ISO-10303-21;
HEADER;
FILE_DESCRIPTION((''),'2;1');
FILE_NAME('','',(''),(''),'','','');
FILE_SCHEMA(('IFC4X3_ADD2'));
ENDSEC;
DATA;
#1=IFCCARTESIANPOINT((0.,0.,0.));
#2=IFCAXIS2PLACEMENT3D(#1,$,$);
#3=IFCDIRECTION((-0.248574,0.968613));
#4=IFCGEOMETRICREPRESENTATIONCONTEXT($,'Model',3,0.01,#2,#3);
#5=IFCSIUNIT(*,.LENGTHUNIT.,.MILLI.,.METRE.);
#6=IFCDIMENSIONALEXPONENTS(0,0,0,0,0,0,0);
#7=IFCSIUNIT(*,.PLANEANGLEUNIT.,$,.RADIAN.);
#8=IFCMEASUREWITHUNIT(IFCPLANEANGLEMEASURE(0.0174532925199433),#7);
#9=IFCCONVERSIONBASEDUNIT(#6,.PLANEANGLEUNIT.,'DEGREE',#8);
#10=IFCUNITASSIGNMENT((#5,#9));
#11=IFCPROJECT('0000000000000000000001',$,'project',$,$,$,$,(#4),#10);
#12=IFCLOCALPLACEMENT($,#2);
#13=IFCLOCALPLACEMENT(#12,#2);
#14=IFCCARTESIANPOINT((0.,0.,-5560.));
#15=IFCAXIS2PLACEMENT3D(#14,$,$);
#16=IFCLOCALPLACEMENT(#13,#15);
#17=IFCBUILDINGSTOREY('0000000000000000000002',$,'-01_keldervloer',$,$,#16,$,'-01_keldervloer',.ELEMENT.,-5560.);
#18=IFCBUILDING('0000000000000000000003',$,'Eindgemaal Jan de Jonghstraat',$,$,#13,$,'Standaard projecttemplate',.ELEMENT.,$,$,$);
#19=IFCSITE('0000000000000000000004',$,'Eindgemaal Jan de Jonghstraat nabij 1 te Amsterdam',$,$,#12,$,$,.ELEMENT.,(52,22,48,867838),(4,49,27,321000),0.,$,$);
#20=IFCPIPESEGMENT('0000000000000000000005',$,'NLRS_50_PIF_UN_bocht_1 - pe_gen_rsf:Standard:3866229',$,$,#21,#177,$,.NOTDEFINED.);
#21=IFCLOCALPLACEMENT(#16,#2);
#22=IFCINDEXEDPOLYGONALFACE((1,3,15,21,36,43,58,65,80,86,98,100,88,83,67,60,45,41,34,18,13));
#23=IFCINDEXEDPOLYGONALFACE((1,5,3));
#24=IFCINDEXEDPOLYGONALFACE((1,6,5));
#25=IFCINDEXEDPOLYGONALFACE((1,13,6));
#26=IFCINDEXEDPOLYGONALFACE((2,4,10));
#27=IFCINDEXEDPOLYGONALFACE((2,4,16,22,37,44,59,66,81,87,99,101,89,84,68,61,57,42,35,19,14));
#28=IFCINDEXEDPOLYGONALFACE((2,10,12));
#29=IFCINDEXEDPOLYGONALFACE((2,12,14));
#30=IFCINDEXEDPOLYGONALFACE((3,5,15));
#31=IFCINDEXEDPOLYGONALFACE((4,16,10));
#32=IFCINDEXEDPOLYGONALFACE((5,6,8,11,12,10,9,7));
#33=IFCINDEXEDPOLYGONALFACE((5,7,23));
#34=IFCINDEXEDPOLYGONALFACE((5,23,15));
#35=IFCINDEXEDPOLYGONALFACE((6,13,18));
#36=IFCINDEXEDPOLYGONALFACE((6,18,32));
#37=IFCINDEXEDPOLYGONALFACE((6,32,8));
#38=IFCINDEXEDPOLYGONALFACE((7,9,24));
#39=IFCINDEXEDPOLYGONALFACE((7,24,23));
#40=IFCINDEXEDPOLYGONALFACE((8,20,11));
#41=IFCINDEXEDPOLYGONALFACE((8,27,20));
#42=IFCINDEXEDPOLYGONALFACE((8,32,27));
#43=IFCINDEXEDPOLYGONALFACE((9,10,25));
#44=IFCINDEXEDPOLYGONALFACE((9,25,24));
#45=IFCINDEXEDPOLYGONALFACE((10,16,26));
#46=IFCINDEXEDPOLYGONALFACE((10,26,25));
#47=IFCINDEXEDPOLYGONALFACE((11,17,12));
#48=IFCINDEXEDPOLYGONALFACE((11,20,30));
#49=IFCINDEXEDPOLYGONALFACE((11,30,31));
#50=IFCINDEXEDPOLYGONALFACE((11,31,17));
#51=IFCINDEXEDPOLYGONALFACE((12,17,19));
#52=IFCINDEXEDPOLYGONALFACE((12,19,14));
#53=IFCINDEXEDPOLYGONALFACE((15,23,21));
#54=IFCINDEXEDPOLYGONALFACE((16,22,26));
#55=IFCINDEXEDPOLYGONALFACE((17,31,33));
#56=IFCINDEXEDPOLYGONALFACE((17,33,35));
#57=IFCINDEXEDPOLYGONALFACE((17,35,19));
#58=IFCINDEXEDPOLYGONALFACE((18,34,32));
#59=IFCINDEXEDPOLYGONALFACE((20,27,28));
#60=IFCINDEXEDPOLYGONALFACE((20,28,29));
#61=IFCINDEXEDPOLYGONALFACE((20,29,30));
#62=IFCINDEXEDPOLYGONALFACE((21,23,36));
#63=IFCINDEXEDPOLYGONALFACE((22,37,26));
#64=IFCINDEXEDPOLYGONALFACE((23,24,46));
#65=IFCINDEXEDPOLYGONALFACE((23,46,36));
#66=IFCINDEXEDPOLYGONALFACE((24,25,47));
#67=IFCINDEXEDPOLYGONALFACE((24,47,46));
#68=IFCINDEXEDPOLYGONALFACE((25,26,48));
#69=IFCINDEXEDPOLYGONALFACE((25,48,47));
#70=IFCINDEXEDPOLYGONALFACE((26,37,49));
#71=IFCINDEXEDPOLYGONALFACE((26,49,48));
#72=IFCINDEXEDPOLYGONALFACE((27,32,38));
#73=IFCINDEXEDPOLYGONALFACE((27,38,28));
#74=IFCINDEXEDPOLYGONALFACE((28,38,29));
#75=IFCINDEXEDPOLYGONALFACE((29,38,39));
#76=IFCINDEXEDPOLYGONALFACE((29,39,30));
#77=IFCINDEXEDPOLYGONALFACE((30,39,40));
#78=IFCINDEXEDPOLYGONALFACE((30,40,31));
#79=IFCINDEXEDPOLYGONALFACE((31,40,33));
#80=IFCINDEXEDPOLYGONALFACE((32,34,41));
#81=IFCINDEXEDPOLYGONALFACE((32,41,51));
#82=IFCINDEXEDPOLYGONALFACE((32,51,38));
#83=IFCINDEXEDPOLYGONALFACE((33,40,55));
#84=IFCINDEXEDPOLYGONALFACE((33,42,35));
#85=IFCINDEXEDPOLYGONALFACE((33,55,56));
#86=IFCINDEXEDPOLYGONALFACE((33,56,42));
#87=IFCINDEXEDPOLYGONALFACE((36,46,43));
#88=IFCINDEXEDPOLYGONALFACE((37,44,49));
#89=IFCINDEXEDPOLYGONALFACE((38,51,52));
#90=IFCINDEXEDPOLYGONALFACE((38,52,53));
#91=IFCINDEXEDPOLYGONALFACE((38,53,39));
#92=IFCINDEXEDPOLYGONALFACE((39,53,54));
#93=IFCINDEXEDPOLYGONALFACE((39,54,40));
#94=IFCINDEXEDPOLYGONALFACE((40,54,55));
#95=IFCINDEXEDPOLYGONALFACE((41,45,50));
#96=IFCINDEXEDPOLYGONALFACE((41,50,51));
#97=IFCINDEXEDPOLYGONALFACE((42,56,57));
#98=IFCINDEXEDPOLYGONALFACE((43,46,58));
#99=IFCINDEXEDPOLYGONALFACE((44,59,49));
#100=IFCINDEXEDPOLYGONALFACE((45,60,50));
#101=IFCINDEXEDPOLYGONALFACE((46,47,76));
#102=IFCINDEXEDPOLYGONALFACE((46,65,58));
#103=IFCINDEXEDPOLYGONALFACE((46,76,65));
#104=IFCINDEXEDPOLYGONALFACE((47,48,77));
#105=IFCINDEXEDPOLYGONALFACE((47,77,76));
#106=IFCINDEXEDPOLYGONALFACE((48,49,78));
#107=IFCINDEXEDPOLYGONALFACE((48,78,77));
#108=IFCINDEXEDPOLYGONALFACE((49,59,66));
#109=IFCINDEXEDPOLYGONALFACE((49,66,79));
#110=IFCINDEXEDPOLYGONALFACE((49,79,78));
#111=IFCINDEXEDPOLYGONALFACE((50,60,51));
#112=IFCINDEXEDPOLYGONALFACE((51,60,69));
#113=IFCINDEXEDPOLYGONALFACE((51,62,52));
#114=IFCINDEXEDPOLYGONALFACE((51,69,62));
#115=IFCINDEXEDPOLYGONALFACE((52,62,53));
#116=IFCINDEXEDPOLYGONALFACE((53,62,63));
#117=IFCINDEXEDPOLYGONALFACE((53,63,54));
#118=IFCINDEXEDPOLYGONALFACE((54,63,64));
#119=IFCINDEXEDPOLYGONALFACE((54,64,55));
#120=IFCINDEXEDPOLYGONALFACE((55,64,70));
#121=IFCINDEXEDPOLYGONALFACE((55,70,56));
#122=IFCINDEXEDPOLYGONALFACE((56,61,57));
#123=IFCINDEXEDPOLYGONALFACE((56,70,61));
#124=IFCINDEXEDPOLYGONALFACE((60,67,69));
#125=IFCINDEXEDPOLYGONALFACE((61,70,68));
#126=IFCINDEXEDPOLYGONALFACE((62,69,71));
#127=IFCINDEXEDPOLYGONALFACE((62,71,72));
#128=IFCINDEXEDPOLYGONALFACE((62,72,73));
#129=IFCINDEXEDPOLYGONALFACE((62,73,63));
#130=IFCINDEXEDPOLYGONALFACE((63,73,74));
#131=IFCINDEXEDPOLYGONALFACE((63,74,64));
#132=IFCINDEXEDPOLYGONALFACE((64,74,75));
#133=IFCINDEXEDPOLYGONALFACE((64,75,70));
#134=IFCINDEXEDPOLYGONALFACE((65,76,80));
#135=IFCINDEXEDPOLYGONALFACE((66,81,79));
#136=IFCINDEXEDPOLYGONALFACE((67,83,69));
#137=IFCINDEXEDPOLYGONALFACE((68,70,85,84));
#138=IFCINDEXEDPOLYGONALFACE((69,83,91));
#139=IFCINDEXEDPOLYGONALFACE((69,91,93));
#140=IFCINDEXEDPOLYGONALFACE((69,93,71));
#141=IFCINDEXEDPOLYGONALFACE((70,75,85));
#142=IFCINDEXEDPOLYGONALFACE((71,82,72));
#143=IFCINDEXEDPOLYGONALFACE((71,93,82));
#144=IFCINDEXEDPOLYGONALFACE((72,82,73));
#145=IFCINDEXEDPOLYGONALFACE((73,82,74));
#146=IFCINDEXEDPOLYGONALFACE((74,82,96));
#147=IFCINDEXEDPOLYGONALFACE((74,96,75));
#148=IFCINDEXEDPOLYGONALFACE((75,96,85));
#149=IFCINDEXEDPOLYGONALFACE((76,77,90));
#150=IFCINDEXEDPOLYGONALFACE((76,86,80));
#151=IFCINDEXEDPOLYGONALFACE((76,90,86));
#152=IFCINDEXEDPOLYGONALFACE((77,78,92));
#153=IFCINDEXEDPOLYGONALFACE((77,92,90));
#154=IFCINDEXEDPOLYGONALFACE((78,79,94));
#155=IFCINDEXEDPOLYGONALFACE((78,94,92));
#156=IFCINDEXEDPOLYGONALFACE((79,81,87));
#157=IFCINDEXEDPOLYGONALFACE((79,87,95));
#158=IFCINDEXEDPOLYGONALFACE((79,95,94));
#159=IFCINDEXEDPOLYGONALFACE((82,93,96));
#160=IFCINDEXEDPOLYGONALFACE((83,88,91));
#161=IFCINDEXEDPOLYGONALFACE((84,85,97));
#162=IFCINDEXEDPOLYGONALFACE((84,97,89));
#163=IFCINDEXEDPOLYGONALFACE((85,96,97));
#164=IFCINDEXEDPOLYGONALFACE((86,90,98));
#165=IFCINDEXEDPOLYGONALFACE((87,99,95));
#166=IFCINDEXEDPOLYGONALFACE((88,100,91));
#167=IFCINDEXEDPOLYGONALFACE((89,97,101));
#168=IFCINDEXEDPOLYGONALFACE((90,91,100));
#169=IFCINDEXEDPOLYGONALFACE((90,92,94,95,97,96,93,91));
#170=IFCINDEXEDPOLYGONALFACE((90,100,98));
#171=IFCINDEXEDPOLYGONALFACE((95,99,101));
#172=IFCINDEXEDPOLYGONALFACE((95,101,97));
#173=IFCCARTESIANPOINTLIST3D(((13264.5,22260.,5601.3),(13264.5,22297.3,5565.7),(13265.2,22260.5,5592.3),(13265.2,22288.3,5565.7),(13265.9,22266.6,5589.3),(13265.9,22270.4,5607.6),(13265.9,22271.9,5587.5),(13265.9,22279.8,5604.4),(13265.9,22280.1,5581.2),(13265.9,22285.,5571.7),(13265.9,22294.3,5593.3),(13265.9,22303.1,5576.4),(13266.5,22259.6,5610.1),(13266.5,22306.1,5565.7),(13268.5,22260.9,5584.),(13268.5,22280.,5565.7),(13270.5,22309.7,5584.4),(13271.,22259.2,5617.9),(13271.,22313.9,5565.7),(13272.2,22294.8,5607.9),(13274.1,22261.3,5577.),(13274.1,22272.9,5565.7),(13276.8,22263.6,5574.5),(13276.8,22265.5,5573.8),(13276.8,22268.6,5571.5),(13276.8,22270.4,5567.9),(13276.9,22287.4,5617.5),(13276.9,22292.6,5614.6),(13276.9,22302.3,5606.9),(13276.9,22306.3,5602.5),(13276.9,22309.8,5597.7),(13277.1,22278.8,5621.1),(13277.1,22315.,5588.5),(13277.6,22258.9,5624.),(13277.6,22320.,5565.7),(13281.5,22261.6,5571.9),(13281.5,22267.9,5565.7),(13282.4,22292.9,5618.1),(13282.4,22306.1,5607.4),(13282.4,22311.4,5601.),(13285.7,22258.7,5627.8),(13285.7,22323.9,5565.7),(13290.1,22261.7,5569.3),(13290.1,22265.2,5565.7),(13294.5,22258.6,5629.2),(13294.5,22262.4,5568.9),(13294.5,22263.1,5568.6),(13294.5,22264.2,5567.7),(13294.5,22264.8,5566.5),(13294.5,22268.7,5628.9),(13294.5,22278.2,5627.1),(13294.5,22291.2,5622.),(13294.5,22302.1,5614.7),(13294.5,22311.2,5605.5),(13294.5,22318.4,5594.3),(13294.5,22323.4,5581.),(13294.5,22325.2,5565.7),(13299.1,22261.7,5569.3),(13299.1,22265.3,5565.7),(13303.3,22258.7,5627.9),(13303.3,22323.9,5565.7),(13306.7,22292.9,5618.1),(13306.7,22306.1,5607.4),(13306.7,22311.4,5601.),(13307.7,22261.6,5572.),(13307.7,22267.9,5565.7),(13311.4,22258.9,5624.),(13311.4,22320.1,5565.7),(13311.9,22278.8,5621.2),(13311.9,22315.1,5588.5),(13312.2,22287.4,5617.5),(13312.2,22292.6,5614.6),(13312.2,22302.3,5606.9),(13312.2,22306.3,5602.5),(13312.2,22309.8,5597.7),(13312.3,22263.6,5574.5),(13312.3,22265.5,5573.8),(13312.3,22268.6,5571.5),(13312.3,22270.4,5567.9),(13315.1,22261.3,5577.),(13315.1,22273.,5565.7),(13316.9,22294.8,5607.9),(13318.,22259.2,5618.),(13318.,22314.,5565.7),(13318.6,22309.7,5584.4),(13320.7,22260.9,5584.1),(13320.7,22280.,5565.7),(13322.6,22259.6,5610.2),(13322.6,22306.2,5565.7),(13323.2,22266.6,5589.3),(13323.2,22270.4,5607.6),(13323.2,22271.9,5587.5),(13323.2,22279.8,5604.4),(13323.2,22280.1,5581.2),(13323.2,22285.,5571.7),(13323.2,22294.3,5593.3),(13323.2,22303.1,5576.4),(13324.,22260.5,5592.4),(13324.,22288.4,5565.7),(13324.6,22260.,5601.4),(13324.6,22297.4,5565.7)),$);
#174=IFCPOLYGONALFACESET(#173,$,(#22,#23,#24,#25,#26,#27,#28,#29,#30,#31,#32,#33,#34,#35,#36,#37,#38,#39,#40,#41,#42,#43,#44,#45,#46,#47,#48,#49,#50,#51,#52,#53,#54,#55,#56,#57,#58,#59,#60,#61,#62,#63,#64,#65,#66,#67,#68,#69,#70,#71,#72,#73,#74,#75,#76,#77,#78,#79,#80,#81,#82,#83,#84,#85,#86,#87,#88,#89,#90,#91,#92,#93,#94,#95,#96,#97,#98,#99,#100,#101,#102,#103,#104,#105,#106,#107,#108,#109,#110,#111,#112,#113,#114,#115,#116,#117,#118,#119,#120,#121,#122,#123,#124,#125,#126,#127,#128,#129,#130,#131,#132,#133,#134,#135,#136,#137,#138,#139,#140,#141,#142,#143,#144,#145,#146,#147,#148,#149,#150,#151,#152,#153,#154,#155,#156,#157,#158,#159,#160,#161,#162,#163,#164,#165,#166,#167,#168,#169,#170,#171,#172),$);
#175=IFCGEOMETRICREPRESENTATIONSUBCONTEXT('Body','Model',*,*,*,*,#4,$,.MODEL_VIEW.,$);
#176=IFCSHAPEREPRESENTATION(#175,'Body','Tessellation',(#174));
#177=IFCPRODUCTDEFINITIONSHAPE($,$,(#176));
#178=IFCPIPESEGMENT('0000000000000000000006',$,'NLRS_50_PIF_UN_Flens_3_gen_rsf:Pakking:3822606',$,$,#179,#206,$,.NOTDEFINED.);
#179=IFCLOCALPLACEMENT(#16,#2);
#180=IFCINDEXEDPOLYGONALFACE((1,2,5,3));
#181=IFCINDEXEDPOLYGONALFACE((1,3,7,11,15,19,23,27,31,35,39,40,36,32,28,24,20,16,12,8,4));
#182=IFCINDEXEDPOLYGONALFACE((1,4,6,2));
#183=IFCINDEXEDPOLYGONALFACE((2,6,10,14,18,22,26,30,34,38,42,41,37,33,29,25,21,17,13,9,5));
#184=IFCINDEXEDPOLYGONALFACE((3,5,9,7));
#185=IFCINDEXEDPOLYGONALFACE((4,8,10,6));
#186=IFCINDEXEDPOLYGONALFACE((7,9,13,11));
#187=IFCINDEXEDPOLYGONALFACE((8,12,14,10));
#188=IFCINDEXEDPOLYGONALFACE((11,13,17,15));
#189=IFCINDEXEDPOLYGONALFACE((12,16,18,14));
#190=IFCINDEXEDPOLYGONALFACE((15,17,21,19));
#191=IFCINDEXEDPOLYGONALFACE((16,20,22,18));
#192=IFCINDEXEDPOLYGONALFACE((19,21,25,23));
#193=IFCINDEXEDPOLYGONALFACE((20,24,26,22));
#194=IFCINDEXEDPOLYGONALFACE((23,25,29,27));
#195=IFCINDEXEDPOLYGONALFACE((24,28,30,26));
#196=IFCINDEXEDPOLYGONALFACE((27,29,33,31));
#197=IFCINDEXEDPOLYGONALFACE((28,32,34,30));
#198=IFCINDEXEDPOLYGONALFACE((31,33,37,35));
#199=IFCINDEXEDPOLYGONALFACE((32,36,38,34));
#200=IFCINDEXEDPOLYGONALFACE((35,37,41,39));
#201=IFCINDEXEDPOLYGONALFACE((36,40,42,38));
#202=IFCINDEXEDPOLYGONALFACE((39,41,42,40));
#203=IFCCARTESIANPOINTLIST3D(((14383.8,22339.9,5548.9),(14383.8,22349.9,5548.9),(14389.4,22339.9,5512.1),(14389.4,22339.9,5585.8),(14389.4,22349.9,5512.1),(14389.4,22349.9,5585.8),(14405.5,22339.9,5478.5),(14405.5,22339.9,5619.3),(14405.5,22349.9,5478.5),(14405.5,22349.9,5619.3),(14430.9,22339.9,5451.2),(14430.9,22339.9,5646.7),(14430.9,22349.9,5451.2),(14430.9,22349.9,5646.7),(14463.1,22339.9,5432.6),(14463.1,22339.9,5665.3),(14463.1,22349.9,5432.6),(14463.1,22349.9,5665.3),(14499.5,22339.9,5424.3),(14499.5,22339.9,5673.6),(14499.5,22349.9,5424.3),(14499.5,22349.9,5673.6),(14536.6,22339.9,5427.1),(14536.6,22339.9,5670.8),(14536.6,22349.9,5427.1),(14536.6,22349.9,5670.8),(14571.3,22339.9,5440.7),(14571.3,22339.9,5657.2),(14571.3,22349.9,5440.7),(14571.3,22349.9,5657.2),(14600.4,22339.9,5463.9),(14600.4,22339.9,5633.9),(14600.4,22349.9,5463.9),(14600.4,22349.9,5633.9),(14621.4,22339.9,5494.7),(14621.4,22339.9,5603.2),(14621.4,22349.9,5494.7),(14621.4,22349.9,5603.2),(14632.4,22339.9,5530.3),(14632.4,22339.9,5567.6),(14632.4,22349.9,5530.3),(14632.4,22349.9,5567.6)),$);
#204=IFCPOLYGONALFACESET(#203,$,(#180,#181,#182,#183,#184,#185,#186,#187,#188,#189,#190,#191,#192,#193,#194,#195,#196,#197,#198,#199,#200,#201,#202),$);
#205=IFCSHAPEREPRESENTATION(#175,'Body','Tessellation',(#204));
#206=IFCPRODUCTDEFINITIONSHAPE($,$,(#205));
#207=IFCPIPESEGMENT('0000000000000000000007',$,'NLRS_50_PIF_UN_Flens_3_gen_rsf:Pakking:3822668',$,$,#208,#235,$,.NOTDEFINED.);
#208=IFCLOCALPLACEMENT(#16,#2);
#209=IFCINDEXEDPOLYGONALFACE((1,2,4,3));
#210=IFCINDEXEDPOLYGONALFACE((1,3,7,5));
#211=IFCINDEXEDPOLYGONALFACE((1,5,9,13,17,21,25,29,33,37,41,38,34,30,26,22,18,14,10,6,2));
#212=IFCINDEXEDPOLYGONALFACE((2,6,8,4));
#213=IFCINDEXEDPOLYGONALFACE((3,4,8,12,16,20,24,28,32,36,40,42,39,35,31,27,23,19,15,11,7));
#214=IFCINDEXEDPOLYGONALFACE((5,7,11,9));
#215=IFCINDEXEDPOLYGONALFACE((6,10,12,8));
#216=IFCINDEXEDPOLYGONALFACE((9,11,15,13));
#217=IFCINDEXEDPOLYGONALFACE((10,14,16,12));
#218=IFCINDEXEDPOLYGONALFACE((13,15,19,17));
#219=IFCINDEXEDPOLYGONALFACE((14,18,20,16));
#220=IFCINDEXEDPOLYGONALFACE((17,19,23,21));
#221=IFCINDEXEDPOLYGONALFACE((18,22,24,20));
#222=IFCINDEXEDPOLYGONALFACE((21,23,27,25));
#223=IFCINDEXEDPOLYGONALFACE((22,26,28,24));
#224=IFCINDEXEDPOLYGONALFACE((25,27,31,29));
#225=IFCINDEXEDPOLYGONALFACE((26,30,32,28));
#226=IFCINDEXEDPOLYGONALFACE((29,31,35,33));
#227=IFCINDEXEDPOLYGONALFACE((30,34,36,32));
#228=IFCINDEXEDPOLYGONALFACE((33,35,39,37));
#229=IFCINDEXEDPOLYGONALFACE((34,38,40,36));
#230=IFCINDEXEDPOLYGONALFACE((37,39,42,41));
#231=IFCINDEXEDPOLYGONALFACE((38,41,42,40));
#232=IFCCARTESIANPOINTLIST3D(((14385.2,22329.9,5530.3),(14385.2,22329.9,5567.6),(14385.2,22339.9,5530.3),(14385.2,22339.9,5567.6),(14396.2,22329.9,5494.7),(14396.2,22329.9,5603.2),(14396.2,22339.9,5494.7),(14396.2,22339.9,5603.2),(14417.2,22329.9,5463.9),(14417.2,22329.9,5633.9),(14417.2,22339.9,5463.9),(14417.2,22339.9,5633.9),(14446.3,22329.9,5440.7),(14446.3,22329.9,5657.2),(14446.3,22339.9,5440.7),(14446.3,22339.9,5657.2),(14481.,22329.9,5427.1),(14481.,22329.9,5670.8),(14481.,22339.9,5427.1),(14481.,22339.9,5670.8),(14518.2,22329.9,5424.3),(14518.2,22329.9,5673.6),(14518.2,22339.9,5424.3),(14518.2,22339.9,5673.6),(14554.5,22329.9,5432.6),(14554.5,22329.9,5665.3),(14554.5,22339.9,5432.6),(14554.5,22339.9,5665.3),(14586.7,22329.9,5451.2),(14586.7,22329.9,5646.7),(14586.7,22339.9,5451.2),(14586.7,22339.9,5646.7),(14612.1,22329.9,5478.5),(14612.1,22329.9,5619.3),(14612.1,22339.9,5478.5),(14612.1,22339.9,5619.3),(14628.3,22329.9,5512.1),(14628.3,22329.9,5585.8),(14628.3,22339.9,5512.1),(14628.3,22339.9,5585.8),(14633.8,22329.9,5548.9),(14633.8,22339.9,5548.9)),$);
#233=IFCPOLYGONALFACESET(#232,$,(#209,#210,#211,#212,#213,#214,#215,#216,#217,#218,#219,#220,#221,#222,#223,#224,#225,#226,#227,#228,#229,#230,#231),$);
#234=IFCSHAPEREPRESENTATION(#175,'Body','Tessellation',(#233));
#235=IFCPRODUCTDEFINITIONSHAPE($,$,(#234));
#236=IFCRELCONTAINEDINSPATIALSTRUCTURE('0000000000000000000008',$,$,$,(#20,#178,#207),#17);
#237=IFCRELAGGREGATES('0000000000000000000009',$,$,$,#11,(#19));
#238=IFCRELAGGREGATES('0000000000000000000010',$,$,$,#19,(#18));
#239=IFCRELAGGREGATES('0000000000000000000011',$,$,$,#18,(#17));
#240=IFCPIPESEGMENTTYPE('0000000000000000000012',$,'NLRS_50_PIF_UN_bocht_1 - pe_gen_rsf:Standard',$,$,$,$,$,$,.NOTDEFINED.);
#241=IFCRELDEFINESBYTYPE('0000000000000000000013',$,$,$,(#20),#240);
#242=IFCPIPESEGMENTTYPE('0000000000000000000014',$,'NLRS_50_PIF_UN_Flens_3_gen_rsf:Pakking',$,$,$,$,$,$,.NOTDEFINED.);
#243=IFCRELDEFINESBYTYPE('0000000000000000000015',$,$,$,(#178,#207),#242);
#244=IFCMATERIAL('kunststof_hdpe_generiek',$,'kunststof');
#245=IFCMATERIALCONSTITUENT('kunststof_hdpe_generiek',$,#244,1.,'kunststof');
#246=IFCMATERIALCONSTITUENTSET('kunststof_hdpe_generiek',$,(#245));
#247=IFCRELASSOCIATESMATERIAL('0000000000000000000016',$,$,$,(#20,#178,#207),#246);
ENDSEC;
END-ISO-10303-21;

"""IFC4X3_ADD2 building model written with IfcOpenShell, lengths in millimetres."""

from ifc_helpers import new_model, entity, si_unit, converted_unit, direction, frame, frame_2d, origin, place, context, subcontext, project, spatial, circle, extrude, source, transform, mapped, material, constituent, constituent_set, type_object, type_shapes, element, save


model = new_model("IFC4X3_ADD2")

# Units and contexts
model_context = context("Model", 3, precision=0.01, world=origin(), true_north=direction((-0.248574, 0.968613)))
body_context = subcontext(model_context, "Body", "Model", "MODEL_VIEW")
ifc_project = project(units=[si_unit("LENGTHUNIT", "METRE", prefix="MILLI"), converted_unit("PLANEANGLEUNIT", "DEGREE", entity("IfcPlaneAngleMeasure", 0.0174532925199433), si_unit("PLANEANGLEUNIT", "RADIAN"), dimensions=[0, 0, 0, 0, 0, 0, 0])], contexts=[model_context])

# Site, building, storey
site_placement = place(None, origin())
site = spatial("IfcSite", under=ifc_project, at=site_placement, Name="Eindgemaal Jan de Jonghstraat nabij 1 te Amsterdam", CompositionType="ELEMENT", RefLatitude=(52, 22, 48, 867838), RefLongitude=(4, 49, 27, 321000), RefElevation=0.0)
building_placement = place(site_placement, origin())
building = spatial("IfcBuilding", under=site, at=building_placement, Name="Eindgemaal Jan de Jonghstraat", LongName="Standaard projecttemplate", CompositionType="ELEMENT")
storey_placement = place(building_placement, frame((0.0, 0.0, -5560.0)))
storey = spatial("IfcBuildingStorey", under=building, at=storey_placement, Name="-01_keldervloer", LongName="-01_keldervloer", CompositionType="ELEMENT", Elevation=-5560.0)

# Pipe segments
ifc_material_1 = material(Name="kunststof_hdpe_generiek", Category="kunststof")
ifc_constituent_1 = constituent(ifc_material_1, Name="kunststof_hdpe_generiek", Category="kunststof", fraction=1.0)
ifc_constituent_set_1 = constituent_set(constituents=[ifc_constituent_1], Name="kunststof_hdpe_generiek")
pipe_segment_type_1 = type_object("IfcPipeSegmentType", Name="NLRS_50_PIF_UN_bocht_1 - pe_gen_rsf:Standard", PredefinedType="NOTDEFINED")
trimmed_curve = entity("IfcTrimmedCurve", entity("IfcCircle", entity("IfcAxis2Placement2D", entity("IfcCartesianPoint", [-3.2, 0.0]), entity("IfcDirection", [0.0, 1.0])), 3.2), [entity("IfcParameterValue", 270.0)], [entity("IfcParameterValue", 0.0)], True, "PARAMETER")
shared_shape_1 = source(origin(), body_context, "Body", "AdvancedSweptSolid", [
    entity("IfcSurfaceCurveSweptAreaSolid", entity("IfcCircleProfileDef", "AREA", None, entity("IfcAxis2Placement2D", entity("IfcCartesianPoint", [30.1, 0.0]), entity("IfcDirection", [1.0, 0.0])), 30.1), entity("IfcAxis2Placement3D", entity("IfcCartesianPoint", [-30.1, 33.3, 0.0]), entity("IfcDirection", [0.0, 0.0, -1.0]), entity("IfcDirection", [1.0, 0.0, 0.0])), trimmed_curve, entity("IfcParameterValue", 0.0), entity("IfcParameterValue", 90.0), entity("IfcSurfaceOfLinearExtrusion", entity("IfcArbitraryOpenProfileDef", "CURVE", None, trimmed_curve), entity("IfcAxis2Placement3D", entity("IfcCartesianPoint", [0.0, 0.0, -304.8])), entity("IfcDirection", [0.0, 0.0, 1.0]), 1.0)),
])
type_shapes(pipe_segment_type_1, [shared_shape_1])
pipe_segment_1_placement = place(storey_placement, frame((13294.5, 22295.1, 5599.1), z_axis=(-1.0, 0.0, 0.0), x_axis=(0.0, 1.0, 0.0)))
element("IfcPipeSegment", 1, at=pipe_segment_1_placement, inside=storey, type_object=pipe_segment_type_1, material=ifc_constituent_set_1, Name="NLRS_50_PIF_UN_bocht_1 - pe_gen_rsf:Standard:3866229", PredefinedType="NOTDEFINED", context=body_context, shape_type="MappedRepresentation", body=[
    mapped(shared_shape_1, transform((0.0, 0.0, 0.0), scale=1.0)),
])
pipe_segment_type_2 = type_object("IfcPipeSegmentType", Name="NLRS_50_PIF_UN_Flens_3_gen_rsf:Pakking", PredefinedType="NOTDEFINED")
shared_shape_2 = source(origin(), body_context, "Body", "SweptSolid", [
    extrude(circle(Radius=125.0, at=frame_2d((0.0, 0.0), x_axis=(1.0, 0.0))), frame((0.0, 0.0, 0.0), z_axis=(0.0, 0.0, 1.0), x_axis=(0.0, -1.0, 0.0)), (0.0, 0.0, 1.0), 10.0),
])
type_shapes(pipe_segment_type_2, [shared_shape_2])
for number, where, z_axis, x_axis, name in (
    (2, (14508.8, 22339.9, 5548.9), (-0.000034, 1.0, 0.0), (0.0, 0.0, 1.0), "NLRS_50_PIF_UN_Flens_3_gen_rsf:Pakking:3822606"),
    (3, (14508.8, 22339.9, 5548.9), (0.000034, -1.0, 0.0), (0.0, 0.0, 1.0), "NLRS_50_PIF_UN_Flens_3_gen_rsf:Pakking:3822668"),
):
    element("IfcPipeSegment", number, at=place(storey_placement, frame(where, z_axis=z_axis, x_axis=x_axis)), inside=storey, type_object=pipe_segment_type_2, material=ifc_constituent_set_1, Name=name, PredefinedType="NOTDEFINED", context=body_context, shape_type="MappedRepresentation", body=[
        mapped(shared_shape_2, transform((0.0, 0.0, 0.0), scale=1.0)),
    ])

save(model, "model.ifc")
